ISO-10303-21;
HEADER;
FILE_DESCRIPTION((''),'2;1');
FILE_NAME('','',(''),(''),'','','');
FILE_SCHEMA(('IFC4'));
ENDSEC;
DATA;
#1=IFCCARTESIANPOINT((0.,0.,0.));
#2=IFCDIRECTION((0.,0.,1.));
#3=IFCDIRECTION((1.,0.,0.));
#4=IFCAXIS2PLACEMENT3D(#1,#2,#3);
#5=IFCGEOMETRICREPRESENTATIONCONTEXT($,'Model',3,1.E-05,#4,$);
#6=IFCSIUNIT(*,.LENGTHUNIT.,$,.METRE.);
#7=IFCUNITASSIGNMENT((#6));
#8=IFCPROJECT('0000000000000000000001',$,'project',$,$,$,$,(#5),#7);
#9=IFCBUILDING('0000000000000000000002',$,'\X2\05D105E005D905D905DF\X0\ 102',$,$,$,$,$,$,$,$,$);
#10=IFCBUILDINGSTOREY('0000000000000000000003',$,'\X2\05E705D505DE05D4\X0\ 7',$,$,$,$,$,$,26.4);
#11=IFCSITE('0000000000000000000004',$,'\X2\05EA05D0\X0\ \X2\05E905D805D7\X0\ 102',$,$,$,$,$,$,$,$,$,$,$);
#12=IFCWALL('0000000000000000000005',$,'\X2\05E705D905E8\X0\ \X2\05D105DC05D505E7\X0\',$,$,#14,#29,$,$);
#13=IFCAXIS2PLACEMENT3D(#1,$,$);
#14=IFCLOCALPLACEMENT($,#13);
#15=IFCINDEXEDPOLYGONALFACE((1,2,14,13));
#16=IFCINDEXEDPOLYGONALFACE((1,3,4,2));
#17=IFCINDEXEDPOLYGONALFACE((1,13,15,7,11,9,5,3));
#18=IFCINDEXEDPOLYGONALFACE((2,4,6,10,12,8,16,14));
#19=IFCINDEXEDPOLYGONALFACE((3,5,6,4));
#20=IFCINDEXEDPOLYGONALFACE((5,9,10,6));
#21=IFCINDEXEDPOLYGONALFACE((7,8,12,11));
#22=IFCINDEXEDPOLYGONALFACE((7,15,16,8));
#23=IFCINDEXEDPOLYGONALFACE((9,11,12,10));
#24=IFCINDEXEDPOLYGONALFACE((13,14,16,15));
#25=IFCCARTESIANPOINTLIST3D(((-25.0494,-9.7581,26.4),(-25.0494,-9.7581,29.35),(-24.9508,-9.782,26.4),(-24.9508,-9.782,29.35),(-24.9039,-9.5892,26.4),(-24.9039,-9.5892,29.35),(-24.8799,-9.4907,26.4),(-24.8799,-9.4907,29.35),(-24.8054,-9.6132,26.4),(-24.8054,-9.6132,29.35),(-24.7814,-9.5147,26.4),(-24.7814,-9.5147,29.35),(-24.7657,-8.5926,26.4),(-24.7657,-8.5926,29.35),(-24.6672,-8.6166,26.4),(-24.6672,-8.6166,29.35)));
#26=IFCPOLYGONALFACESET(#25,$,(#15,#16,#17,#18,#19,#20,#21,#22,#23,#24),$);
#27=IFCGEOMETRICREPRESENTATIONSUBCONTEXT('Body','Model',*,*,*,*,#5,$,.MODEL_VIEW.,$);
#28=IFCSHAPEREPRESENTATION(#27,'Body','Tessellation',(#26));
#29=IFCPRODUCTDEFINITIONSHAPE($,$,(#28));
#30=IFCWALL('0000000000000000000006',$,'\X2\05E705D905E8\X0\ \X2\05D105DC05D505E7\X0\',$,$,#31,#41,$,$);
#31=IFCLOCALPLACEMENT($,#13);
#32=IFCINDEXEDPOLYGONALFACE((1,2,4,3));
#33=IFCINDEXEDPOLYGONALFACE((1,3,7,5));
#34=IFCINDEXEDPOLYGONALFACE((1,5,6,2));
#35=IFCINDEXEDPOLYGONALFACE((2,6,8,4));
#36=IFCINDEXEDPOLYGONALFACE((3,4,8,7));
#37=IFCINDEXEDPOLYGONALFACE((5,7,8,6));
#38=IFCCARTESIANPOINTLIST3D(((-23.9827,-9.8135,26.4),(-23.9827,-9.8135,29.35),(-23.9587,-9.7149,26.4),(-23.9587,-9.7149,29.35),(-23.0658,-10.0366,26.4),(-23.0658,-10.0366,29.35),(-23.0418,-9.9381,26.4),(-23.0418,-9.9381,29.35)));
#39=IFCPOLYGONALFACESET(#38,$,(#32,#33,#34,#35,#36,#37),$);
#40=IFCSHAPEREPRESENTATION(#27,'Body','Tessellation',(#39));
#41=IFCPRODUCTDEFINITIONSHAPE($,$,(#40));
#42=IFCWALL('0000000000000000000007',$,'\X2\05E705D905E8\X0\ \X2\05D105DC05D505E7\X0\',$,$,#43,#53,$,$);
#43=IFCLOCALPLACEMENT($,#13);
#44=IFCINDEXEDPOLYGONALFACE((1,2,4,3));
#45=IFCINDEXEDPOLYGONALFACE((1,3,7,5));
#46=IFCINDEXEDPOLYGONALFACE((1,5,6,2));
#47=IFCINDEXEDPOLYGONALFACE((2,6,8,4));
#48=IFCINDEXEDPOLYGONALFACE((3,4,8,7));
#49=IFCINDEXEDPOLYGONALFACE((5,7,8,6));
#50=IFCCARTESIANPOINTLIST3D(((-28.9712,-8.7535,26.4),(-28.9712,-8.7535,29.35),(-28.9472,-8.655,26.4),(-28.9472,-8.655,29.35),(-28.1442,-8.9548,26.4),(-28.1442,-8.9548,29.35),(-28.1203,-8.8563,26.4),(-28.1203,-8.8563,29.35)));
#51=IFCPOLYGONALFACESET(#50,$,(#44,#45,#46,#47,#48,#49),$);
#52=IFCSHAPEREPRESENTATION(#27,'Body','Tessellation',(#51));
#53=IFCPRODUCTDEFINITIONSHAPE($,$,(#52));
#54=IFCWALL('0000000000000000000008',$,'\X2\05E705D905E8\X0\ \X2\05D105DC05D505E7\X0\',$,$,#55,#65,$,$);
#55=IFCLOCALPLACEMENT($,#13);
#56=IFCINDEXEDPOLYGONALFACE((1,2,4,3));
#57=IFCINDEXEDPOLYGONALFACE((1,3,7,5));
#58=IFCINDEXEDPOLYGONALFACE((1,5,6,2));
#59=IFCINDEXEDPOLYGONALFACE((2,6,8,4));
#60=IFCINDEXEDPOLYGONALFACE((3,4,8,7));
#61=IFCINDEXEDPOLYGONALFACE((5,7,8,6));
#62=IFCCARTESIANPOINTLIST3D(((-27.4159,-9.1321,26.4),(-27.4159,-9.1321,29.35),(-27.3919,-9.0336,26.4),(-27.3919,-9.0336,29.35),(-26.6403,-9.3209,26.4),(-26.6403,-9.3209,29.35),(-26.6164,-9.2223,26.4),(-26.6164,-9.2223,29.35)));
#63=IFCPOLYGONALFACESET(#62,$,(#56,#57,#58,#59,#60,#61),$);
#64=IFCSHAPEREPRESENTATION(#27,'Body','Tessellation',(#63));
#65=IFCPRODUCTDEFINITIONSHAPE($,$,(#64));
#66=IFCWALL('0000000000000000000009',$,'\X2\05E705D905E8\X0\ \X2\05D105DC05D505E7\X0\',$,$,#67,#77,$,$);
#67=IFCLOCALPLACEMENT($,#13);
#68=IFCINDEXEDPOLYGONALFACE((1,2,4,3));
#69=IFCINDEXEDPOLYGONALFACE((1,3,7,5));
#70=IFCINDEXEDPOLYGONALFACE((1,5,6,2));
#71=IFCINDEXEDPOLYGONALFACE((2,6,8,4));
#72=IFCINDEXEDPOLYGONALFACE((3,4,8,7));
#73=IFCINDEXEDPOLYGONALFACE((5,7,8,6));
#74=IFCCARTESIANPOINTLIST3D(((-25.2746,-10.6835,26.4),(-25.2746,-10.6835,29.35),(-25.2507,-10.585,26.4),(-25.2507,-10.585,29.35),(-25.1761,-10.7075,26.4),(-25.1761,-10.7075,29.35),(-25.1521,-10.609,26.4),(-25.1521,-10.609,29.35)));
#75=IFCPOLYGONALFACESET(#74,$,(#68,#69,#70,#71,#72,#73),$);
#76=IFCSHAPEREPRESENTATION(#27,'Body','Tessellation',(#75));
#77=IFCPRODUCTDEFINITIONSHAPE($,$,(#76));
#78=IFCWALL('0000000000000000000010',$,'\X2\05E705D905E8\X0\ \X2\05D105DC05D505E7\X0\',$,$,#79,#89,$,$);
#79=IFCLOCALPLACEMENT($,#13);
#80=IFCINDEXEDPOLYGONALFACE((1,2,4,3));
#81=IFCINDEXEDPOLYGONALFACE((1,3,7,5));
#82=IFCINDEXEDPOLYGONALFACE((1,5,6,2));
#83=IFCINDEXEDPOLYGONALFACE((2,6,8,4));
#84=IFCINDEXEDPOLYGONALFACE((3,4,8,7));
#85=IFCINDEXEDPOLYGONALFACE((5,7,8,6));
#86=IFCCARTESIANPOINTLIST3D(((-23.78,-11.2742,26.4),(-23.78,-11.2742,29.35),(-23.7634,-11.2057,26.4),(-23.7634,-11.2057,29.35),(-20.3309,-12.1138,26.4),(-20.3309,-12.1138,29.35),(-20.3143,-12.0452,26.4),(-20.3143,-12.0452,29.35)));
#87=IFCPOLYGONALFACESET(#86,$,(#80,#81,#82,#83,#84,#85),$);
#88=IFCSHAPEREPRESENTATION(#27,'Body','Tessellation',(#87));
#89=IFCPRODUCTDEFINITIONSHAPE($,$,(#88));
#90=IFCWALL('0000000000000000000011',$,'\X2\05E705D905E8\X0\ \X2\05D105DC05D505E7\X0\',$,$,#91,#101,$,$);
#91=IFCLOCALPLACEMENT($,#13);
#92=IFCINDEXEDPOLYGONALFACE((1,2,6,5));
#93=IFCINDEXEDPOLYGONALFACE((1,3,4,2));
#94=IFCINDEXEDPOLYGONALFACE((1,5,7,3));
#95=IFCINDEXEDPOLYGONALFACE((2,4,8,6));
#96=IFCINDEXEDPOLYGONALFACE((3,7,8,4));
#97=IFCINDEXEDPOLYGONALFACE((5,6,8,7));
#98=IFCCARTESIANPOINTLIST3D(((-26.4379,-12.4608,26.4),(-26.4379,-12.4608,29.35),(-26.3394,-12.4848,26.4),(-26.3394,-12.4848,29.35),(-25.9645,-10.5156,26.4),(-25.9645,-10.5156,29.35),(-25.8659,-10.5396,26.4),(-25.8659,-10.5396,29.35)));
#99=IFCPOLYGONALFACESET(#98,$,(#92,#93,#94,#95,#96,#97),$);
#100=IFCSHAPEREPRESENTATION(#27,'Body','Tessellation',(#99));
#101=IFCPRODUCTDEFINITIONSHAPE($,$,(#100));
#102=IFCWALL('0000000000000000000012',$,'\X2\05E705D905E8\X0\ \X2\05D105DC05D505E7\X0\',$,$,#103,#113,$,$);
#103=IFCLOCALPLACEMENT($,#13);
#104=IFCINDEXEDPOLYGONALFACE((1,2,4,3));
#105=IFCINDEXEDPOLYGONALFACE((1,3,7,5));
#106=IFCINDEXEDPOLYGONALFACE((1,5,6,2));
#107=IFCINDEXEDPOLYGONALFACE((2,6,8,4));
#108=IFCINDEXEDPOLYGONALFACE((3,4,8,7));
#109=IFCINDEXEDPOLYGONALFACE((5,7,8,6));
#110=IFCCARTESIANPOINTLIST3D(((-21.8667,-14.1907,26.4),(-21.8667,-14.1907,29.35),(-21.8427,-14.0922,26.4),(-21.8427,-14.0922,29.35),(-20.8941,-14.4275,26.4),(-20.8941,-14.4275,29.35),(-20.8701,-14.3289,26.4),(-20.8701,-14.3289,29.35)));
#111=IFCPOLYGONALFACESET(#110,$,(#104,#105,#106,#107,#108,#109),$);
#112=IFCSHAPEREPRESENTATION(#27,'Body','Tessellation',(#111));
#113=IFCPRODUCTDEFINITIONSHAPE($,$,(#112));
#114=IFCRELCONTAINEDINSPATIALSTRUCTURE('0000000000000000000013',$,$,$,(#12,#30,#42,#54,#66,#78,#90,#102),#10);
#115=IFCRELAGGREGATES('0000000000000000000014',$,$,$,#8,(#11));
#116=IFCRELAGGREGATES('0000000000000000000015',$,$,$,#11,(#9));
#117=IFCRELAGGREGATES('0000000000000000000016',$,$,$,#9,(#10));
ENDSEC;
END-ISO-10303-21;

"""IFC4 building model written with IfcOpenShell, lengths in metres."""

from ifc_helpers import new_model, si_unit, frame, origin_with_axes, context, subcontext, project, spatial, polyline, outline, extrude, element, save


model = new_model("IFC4")

# Units and contexts
model_context = context("Model", 3, precision=1e-05, world=origin_with_axes())
body_context = subcontext(model_context, "Body", "Model", "MODEL_VIEW")
ifc_project = project(units=[si_unit("LENGTHUNIT", "METRE")], contexts=[model_context])

# Site, building, storey
site = spatial("IfcSite", under=ifc_project, Name="תא שטח 102")
building = spatial("IfcBuilding", under=site, Name="בניין 102")
storey = spatial("IfcBuildingStorey", under=building, Name="קומה 7", Elevation=26.4)

# Walls
element("IfcWall", 1, inside=storey, Name="קיר בלוק", context=body_context, shape_type="SweptSolid", body=[
    extrude(outline(polyline([(-24.8054, -9.6132), (-24.7814, -9.5147), (-24.8799, -9.4907), (-24.6672, -8.6166), (-24.7657, -8.5926), (-25.0494, -9.7581), (-24.9508, -9.782), (-24.9039, -9.5892), (-24.8054, -9.6132)])), frame((0.0, 0.0, 26.4)), (0.0, 0.0, 1.0), 2.95),
])
element("IfcWall", 2, inside=storey, Name="קיר בלוק", context=body_context, shape_type="SweptSolid", body=[
    extrude(outline(polyline([(-23.9587, -9.7149), (-23.9827, -9.8135), (-23.0658, -10.0366), (-23.0418, -9.9381), (-23.9587, -9.7149)])), frame((0.0, 0.0, 26.4)), (0.0, 0.0, 1.0), 2.95),
])
element("IfcWall", 3, inside=storey, Name="קיר בלוק", context=body_context, shape_type="SweptSolid", body=[
    extrude(outline(polyline([(-28.9712, -8.7535), (-28.1442, -8.9548), (-28.1203, -8.8563), (-28.9472, -8.655), (-28.9712, -8.7535)])), frame((0.0, 0.0, 26.4)), (0.0, 0.0, 1.0), 2.95),
])
element("IfcWall", 4, inside=storey, Name="קיר בלוק", context=body_context, shape_type="SweptSolid", body=[
    extrude(outline(polyline([(-27.3919, -9.0336), (-27.4159, -9.1321), (-26.6403, -9.3209), (-26.6164, -9.2223), (-27.3919, -9.0336)])), frame((0.0, 0.0, 26.4)), (0.0, 0.0, 1.0), 2.95),
])
element("IfcWall", 5, inside=storey, Name="קיר בלוק", context=body_context, shape_type="SweptSolid", body=[
    extrude(outline(polyline([(-25.1521, -10.609), (-25.2507, -10.585), (-25.2746, -10.6835), (-25.1761, -10.7075), (-25.1521, -10.609)])), frame((0.0, 0.0, 26.4)), (0.0, 0.0, 1.0), 2.95),
])
element("IfcWall", 6, inside=storey, Name="קיר בלוק", context=body_context, shape_type="SweptSolid", body=[
    extrude(outline(polyline([(-23.7634, -11.2057), (-23.78, -11.2742), (-20.3309, -12.1138), (-20.3143, -12.0452), (-23.7634, -11.2057)])), frame((0.0, 0.0, 26.4)), (0.0, 0.0, 1.0), 2.95),
])
element("IfcWall", 7, inside=storey, Name="קיר בלוק", context=body_context, shape_type="SweptSolid", body=[
    extrude(outline(polyline([(-26.4379, -12.4608), (-26.3394, -12.4848), (-25.8659, -10.5396), (-25.9645, -10.5156), (-26.4379, -12.4608)])), frame((0.0, 0.0, 26.4)), (0.0, 0.0, 1.0), 2.95),
])
element("IfcWall", 8, inside=storey, Name="קיר בלוק", context=body_context, shape_type="SweptSolid", body=[
    extrude(outline(polyline([(-20.8701, -14.3289), (-21.8427, -14.0922), (-21.8667, -14.1907), (-20.8941, -14.4275), (-20.8701, -14.3289)])), frame((0.0, 0.0, 26.4)), (0.0, 0.0, 1.0), 2.95),
])

save(model, "model.ifc")
